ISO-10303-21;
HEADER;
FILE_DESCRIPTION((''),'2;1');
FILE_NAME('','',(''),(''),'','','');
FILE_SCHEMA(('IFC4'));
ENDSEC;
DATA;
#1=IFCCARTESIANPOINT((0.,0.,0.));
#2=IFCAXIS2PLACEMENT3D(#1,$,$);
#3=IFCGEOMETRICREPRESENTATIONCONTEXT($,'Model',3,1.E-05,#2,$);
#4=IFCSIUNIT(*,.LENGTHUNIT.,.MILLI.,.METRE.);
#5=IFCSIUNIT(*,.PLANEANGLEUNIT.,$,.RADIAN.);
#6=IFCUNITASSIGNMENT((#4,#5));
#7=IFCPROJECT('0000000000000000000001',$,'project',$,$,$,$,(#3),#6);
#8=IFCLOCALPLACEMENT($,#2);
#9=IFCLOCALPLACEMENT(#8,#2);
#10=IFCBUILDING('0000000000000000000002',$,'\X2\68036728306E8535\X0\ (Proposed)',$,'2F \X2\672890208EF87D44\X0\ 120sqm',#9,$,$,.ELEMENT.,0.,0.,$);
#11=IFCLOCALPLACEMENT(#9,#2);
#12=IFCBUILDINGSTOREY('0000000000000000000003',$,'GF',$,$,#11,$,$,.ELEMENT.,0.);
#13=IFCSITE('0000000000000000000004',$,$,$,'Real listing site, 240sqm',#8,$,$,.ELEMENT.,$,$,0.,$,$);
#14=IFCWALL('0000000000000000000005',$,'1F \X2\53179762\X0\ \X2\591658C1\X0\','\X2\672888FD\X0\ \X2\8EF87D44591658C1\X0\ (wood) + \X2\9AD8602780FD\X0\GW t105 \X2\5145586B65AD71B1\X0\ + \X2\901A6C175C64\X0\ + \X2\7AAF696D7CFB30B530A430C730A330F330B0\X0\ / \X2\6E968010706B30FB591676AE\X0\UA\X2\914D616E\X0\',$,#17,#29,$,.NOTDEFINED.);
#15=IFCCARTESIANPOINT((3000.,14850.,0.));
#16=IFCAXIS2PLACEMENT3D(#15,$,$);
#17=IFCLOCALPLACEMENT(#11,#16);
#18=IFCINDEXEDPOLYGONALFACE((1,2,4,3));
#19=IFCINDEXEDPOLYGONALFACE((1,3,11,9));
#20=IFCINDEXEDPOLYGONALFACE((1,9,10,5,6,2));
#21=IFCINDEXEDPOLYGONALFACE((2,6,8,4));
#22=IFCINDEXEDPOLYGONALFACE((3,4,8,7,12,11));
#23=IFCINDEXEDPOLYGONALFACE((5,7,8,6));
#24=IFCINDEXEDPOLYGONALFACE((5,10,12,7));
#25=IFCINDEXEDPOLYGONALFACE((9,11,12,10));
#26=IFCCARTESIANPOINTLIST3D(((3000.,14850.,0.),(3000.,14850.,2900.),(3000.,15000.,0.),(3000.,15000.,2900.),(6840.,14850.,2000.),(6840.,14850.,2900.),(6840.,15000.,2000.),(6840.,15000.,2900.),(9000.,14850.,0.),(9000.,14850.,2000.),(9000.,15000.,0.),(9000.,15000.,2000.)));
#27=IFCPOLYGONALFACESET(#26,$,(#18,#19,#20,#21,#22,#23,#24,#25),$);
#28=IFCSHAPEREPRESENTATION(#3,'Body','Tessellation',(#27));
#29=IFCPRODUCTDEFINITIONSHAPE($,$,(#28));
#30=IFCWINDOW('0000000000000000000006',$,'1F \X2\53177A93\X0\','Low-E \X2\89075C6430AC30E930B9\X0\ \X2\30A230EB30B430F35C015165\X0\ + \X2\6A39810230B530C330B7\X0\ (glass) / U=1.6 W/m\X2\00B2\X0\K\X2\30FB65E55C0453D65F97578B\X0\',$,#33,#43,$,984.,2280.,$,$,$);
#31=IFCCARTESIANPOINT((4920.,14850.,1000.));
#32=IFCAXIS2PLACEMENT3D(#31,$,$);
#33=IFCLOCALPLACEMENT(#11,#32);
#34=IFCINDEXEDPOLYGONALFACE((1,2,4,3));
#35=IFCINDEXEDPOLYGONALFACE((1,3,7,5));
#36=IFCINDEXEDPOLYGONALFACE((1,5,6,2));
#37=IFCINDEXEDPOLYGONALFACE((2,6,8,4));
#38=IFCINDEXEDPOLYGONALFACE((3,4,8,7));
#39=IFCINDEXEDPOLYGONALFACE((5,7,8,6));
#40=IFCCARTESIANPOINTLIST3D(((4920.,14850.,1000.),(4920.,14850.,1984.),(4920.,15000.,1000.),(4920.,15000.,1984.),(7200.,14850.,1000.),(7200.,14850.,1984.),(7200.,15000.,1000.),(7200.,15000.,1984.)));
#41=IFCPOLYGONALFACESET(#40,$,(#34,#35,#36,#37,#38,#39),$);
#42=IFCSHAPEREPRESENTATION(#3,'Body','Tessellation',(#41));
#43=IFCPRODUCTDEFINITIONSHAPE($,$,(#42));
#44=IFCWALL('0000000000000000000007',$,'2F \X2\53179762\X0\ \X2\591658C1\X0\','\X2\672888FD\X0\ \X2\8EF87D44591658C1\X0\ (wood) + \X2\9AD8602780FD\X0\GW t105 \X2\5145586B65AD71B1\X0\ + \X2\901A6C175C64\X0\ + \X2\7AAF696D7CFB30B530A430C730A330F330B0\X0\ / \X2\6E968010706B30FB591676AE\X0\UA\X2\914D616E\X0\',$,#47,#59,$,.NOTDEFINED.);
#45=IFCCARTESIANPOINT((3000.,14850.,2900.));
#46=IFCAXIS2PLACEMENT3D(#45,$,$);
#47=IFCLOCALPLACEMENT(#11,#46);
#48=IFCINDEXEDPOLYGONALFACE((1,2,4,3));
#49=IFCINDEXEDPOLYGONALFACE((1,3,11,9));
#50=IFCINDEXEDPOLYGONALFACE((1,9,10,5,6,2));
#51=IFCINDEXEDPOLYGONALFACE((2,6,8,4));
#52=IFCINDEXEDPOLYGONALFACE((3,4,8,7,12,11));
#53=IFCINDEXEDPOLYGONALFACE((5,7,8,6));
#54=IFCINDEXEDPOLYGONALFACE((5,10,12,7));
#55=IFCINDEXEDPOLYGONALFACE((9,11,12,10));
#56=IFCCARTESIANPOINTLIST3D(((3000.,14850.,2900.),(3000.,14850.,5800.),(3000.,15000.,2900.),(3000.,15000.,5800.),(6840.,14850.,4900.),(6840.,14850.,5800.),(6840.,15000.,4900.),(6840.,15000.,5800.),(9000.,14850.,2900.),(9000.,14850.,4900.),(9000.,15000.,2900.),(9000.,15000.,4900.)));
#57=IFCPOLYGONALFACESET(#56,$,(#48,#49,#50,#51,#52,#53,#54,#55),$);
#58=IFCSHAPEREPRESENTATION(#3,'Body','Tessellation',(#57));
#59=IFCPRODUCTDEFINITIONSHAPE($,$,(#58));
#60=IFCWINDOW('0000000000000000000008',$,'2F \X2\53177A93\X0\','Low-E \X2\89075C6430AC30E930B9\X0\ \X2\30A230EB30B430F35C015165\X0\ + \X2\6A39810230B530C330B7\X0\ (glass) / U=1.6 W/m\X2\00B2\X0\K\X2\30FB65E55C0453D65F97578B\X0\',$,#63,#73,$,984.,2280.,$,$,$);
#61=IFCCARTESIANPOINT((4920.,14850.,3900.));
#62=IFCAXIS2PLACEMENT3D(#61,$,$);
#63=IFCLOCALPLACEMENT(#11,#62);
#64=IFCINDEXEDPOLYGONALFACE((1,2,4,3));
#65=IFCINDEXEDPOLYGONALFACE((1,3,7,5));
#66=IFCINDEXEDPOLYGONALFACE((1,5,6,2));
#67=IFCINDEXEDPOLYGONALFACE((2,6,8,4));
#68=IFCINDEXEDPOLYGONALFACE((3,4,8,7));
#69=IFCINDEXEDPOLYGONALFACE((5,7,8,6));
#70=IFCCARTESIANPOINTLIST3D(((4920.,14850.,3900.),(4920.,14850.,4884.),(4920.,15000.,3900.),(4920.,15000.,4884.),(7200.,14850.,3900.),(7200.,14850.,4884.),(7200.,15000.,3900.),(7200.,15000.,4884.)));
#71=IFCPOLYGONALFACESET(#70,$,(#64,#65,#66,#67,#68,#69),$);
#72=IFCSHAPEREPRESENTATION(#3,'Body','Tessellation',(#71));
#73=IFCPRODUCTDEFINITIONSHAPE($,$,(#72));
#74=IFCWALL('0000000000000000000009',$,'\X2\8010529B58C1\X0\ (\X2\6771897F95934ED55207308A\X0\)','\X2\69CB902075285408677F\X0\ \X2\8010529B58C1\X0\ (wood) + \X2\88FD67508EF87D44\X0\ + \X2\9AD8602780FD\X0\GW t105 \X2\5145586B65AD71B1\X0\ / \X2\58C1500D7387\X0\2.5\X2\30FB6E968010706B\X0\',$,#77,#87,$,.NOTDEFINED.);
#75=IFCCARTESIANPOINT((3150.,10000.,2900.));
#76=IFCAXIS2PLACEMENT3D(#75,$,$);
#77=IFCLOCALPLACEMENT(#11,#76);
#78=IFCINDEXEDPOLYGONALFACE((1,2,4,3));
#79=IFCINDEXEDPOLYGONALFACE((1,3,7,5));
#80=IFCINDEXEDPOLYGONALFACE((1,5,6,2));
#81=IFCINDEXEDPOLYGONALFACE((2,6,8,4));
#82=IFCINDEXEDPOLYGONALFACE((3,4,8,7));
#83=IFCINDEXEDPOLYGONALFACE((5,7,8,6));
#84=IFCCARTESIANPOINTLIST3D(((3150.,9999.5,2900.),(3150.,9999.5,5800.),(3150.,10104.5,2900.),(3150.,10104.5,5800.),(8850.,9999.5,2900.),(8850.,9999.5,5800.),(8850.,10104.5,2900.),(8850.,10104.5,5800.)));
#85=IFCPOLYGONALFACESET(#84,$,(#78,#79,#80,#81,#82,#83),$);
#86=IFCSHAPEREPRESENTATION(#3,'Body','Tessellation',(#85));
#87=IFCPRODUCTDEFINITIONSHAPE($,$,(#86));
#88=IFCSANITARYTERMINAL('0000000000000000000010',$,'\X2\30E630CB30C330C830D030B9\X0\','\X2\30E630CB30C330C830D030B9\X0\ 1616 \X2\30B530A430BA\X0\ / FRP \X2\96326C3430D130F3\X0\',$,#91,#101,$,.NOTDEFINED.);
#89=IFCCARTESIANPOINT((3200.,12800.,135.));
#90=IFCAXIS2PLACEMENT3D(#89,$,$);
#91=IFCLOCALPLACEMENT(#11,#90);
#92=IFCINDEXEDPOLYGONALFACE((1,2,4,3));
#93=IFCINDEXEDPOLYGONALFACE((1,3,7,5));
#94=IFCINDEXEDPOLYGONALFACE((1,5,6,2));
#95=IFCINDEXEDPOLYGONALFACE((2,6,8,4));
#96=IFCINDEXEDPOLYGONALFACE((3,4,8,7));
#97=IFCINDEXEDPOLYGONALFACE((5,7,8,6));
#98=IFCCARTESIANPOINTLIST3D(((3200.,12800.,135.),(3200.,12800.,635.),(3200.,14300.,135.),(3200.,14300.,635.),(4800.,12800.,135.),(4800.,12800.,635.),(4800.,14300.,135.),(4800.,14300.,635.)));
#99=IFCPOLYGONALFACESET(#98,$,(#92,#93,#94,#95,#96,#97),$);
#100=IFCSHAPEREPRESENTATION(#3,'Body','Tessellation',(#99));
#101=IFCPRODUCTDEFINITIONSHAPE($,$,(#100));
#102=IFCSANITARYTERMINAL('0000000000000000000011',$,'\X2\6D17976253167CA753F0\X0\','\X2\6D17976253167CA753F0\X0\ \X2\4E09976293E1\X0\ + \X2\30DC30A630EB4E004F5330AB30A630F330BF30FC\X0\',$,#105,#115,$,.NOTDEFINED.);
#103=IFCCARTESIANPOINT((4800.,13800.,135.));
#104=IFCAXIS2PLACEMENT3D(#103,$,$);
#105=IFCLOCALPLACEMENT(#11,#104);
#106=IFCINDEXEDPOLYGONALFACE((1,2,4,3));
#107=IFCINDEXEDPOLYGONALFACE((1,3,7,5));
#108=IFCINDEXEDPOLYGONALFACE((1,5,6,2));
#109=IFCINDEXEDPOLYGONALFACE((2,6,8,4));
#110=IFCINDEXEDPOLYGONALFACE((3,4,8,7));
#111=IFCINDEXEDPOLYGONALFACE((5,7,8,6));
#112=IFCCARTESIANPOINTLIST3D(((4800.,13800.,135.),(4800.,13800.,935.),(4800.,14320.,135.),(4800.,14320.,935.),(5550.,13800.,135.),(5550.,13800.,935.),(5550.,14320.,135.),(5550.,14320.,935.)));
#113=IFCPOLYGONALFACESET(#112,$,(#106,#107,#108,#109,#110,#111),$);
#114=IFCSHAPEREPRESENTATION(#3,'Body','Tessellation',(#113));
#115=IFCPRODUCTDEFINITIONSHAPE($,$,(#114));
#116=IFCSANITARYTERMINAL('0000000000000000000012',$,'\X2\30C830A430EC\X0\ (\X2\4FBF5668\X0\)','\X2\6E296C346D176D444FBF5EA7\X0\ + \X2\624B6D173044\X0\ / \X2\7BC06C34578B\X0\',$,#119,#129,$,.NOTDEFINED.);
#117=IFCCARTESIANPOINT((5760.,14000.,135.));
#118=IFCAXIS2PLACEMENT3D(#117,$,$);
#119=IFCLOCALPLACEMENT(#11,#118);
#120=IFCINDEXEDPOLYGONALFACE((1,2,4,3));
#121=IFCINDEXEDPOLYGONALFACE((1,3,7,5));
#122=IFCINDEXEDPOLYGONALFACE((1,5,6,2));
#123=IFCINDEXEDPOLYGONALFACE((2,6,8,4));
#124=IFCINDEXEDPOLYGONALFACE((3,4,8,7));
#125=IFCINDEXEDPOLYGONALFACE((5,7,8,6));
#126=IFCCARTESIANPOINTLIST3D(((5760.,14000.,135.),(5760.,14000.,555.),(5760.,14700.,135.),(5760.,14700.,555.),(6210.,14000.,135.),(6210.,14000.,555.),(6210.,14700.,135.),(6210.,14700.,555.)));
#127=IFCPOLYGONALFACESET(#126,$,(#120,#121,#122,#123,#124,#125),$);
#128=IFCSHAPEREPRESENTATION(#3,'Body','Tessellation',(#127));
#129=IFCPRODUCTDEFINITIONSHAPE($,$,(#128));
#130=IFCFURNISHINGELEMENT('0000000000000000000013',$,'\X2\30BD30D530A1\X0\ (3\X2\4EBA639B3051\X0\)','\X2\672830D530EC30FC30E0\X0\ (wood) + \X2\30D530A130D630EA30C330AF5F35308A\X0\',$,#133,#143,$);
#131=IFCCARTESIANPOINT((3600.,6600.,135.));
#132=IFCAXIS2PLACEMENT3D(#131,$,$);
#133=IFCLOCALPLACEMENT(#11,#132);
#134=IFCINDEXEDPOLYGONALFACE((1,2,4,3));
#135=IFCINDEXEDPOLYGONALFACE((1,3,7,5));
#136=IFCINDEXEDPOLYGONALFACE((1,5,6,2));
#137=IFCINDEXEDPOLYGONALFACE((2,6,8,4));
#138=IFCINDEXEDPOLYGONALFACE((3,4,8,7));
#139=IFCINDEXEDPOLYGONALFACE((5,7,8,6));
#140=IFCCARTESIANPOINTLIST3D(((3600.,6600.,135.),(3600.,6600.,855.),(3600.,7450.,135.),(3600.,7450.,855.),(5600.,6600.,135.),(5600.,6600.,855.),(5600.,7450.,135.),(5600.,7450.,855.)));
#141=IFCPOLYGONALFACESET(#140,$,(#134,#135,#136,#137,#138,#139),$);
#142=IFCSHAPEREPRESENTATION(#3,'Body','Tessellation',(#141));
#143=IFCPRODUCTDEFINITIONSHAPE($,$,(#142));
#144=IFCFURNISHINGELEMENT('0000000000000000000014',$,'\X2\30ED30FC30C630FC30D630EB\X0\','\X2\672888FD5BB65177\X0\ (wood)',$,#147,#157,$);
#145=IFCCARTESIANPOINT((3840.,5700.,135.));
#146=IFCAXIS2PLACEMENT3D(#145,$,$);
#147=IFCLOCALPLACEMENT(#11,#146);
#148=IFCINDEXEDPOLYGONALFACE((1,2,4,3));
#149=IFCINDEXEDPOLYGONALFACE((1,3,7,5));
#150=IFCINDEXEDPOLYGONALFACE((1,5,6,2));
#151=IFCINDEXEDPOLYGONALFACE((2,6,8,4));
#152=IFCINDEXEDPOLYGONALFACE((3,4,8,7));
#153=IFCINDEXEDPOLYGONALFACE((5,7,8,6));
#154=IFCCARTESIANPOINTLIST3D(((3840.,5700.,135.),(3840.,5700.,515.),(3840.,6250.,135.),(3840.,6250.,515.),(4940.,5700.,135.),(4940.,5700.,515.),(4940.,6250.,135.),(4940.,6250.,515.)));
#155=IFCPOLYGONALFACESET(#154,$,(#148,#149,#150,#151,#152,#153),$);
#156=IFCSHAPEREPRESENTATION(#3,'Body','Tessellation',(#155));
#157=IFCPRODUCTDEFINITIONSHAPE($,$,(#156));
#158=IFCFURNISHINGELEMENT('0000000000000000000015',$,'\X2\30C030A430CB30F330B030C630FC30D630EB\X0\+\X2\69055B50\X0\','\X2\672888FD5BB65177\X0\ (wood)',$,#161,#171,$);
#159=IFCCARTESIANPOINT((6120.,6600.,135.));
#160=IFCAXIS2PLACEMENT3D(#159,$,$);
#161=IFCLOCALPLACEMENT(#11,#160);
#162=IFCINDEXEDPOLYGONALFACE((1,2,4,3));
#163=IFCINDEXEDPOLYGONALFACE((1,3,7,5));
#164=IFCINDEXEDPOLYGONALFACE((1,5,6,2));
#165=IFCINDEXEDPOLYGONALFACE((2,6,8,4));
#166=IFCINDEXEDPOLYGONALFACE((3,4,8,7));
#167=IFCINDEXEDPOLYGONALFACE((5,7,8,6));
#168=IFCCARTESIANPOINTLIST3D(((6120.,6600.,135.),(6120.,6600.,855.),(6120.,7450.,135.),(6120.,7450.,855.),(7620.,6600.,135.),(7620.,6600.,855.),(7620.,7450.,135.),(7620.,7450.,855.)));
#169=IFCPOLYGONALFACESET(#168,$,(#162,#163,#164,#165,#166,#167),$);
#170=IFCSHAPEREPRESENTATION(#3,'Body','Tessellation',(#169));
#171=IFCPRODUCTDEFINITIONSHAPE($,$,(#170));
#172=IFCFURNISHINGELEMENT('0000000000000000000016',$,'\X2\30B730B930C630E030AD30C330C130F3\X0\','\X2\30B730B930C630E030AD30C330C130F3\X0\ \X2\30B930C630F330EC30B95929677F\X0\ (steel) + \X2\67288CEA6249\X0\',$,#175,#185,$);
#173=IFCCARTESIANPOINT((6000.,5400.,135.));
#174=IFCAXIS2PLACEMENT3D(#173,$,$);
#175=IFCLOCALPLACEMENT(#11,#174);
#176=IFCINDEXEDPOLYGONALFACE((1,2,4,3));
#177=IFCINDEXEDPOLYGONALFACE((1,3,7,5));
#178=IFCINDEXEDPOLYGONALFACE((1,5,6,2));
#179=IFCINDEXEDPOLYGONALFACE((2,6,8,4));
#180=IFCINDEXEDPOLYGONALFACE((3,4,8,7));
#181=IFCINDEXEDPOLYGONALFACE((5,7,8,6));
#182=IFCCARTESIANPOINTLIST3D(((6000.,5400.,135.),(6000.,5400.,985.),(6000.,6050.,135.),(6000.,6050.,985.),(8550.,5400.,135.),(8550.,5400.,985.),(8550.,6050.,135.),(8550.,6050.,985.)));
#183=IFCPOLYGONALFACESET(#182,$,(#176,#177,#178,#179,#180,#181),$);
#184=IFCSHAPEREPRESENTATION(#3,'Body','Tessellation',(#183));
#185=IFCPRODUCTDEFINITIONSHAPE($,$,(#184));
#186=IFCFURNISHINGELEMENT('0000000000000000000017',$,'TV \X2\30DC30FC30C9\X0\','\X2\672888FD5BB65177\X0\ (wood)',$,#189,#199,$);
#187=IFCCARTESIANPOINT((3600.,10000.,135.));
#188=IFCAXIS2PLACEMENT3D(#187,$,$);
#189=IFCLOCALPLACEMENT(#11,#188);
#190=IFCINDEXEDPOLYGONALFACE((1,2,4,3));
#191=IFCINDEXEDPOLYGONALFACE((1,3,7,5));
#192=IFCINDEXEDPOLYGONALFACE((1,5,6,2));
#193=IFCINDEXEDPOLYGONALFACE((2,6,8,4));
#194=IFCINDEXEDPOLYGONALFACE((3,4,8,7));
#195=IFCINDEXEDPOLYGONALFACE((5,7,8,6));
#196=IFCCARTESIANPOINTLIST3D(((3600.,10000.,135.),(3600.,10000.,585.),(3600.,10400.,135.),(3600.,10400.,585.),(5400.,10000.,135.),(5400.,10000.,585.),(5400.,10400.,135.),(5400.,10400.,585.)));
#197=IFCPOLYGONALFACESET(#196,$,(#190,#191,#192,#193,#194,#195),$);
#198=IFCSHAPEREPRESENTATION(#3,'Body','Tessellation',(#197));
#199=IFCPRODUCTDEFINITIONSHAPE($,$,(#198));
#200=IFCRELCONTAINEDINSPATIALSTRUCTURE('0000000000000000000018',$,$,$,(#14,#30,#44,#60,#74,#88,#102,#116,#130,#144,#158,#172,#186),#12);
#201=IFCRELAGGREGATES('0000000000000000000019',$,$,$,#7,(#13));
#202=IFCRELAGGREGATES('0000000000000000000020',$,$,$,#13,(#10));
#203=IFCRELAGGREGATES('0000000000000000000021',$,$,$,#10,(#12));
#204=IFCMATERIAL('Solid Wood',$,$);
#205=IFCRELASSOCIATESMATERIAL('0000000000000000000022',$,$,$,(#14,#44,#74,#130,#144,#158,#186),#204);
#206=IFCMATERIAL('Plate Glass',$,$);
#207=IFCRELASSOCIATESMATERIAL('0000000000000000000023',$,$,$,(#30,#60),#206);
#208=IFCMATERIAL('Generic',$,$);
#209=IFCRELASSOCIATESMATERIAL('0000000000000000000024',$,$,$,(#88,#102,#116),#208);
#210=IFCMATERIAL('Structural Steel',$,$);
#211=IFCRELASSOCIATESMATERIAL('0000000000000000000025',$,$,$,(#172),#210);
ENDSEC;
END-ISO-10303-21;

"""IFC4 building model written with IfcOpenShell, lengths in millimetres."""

from ifc_helpers import new_model, si_unit, frame, frame_2d, origin, place, context, project, spatial, rectangle, extrude, material, element, fill, save


model = new_model("IFC4")

# Units and contexts
model_context = context("Model", 3, precision=1e-05, world=origin())
ifc_project = project(units=[si_unit("LENGTHUNIT", "METRE", prefix="MILLI"), si_unit("PLANEANGLEUNIT", "RADIAN")], contexts=[model_context])

# Site, building, storey
site_placement = place(None, origin())
site = spatial("IfcSite", under=ifc_project, at=site_placement, ObjectType="Real listing site, 240sqm", CompositionType="ELEMENT", RefElevation=0.0)
building_placement = place(site_placement, origin())
building = spatial("IfcBuilding", under=site, at=building_placement, Name="栃木の蔵 (Proposed)", ObjectType="2F 木造軸組 120sqm", CompositionType="ELEMENT", ElevationOfRefHeight=0.0, ElevationOfTerrain=0.0)
storey_placement = place(building_placement, origin())
storey = spatial("IfcBuildingStorey", under=building, at=storey_placement, Name="GF", CompositionType="ELEMENT", Elevation=0.0)

# Wall, opening, window
ifc_material_1 = material(Name="Solid Wood")
wall_1_placement = place(storey_placement, frame((3000.0, 14850.0, 0.0)))
wall_1 = element("IfcWall", 1, at=wall_1_placement, inside=storey, material=ifc_material_1, Name="1F 北面 外壁", Description="木製 軸組外壁 (wood) + 高性能GW t105 充填断熱 + 通気層 + 窯業系サイディング / 準耐火・外皮UA配慮", PredefinedType="NOTDEFINED", context=model_context, shape_type="SweptSolid", body=[
    extrude(rectangle(XDim=6000.0, YDim=150.0, at=frame_2d((3000.0, 75.0))), frame((3000.0, 14850.0, 0.0)), (0.0, 0.0, 1.0), 2900.0),
])
opening_1_placement = place(storey_placement, frame((4920.0, 14850.0, 1000.0)))
opening_1 = element("IfcOpeningElement", 2, at=opening_1_placement, cuts=wall_1, PredefinedType="NOTDEFINED", context=model_context, shape_type="SweptSolid", body=[
    extrude(rectangle(XDim=2280.0, YDim=150.0, at=frame_2d((1140.0, 75.0))), frame((4920.0, 14850.0, 1000.0)), (0.0, 0.0, 1.0), 984.0),
])
ifc_material_2 = material(Name="Plate Glass")
window_1_placement = place(storey_placement, frame((4920.0, 14850.0, 1000.0)))
window_1 = element("IfcWindow", 3, at=window_1_placement, inside=storey, material=ifc_material_2, Name="1F 北窓", Description="Low-E 複層ガラス アルゴン封入 + 樹脂サッシ (glass) / U=1.6 W/m²K・日射取得型", OverallHeight=984.0, OverallWidth=2280.0, context=model_context, shape_type="SweptSolid", body=[
    extrude(rectangle(XDim=2280.0, YDim=150.0, at=frame_2d((1140.0, 75.0))), frame((4920.0, 14850.0, 1000.0)), (0.0, 0.0, 1.0), 984.0),
])
fill(opening_1, window_1)

# Wall, opening, window
wall_2_placement = place(storey_placement, frame((3000.0, 14850.0, 2900.0)))
wall_2 = element("IfcWall", 4, at=wall_2_placement, inside=storey, material=ifc_material_1, Name="2F 北面 外壁", Description="木製 軸組外壁 (wood) + 高性能GW t105 充填断熱 + 通気層 + 窯業系サイディング / 準耐火・外皮UA配慮", PredefinedType="NOTDEFINED", context=model_context, shape_type="SweptSolid", body=[
    extrude(rectangle(XDim=6000.0, YDim=150.0, at=frame_2d((3000.0, 75.0))), frame((3000.0, 14850.0, 2900.0)), (0.0, 0.0, 1.0), 2900.0),
])
opening_2_placement = place(storey_placement, frame((4920.0, 14850.0, 3900.0)))
opening_2 = element("IfcOpeningElement", 5, at=opening_2_placement, cuts=wall_2, PredefinedType="NOTDEFINED", context=model_context, shape_type="SweptSolid", body=[
    extrude(rectangle(XDim=2280.0, YDim=150.0, at=frame_2d((1140.0, 75.0))), frame((4920.0, 14850.0, 3900.0)), (0.0, 0.0, 1.0), 984.0),
])
window_2_placement = place(storey_placement, frame((4920.0, 14850.0, 3900.0)))
window_2 = element("IfcWindow", 6, at=window_2_placement, inside=storey, material=ifc_material_2, Name="2F 北窓", Description="Low-E 複層ガラス アルゴン封入 + 樹脂サッシ (glass) / U=1.6 W/m²K・日射取得型", OverallHeight=984.0, OverallWidth=2280.0, context=model_context, shape_type="SweptSolid", body=[
    extrude(rectangle(XDim=2280.0, YDim=150.0, at=frame_2d((1140.0, 75.0))), frame((4920.0, 14850.0, 3900.0)), (0.0, 0.0, 1.0), 984.0),
])
fill(opening_2, window_2)

# Wall
wall_3_placement = place(storey_placement, frame((3150.0, 10000.0, 2900.0)))
element("IfcWall", 7, at=wall_3_placement, inside=storey, material=ifc_material_1, Name="耐力壁 (東西間仕切り)", Description="構造用合板 耐力壁 (wood) + 製材軸組 + 高性能GW t105 充填断熱 / 壁倍率2.5・準耐火", PredefinedType="NOTDEFINED", context=model_context, shape_type="SweptSolid", body=[
    extrude(rectangle(XDim=5700.0, YDim=105.0, at=frame_2d((2850.0, 52.0))), frame((3150.0, 10000.0, 2900.0)), (0.0, 0.0, 1.0), 2900.0),
])

# Sanitary terminals
ifc_material_3 = material(Name="Generic")
sanitary_terminal_1_placement = place(storey_placement, frame((3200.0, 12800.0, 135.0)))
element("IfcSanitaryTerminal", 8, at=sanitary_terminal_1_placement, inside=storey, material=ifc_material_3, Name="ユニットバス", Description="ユニットバス 1616 サイズ / FRP 防水パン", PredefinedType="NOTDEFINED", context=model_context, shape_type="SweptSolid", body=[
    extrude(rectangle(XDim=1600.0, YDim=1500.0, at=frame_2d((800.0, 750.0))), frame((3200.0, 12800.0, 135.0)), (0.0, 0.0, 1.0), 500.0),
])
sanitary_terminal_2_placement = place(storey_placement, frame((4800.0, 13800.0, 135.0)))
element("IfcSanitaryTerminal", 9, at=sanitary_terminal_2_placement, inside=storey, material=ifc_material_3, Name="洗面化粧台", Description="洗面化粧台 三面鏡 + ボウル一体カウンター", PredefinedType="NOTDEFINED", context=model_context, shape_type="SweptSolid", body=[
    extrude(rectangle(XDim=750.0, YDim=520.0, at=frame_2d((375.0, 260.0))), frame((4800.0, 13800.0, 135.0)), (0.0, 0.0, 1.0), 800.0),
])
sanitary_terminal_3_placement = place(storey_placement, frame((5760.0, 14000.0, 135.0)))
element("IfcSanitaryTerminal", 10, at=sanitary_terminal_3_placement, inside=storey, material=ifc_material_3, Name="トイレ (便器)", Description="温水洗浄便座 + 手洗い / 節水型", PredefinedType="NOTDEFINED", context=model_context, shape_type="SweptSolid", body=[
    extrude(rectangle(XDim=450.0, YDim=700.0, at=frame_2d((225.0, 350.0))), frame((5760.0, 14000.0, 135.0)), (0.0, 0.0, 1.0), 420.0),
])

# Furnishing elements
furnishing_1_placement = place(storey_placement, frame((3600.0, 6600.0, 135.0)))
element("IfcFurnishingElement", 11, at=furnishing_1_placement, inside=storey, material=ifc_material_1, Name="ソファ (3人掛け)", Description="木フレーム (wood) + ファブリック張り", context=model_context, shape_type="SweptSolid", body=[
    extrude(rectangle(XDim=2000.0, YDim=850.0, at=frame_2d((1000.0, 425.0))), frame((3600.0, 6600.0, 135.0)), (0.0, 0.0, 1.0), 720.0),
])
furnishing_2_placement = place(storey_placement, frame((3840.0, 5700.0, 135.0)))
element("IfcFurnishingElement", 12, at=furnishing_2_placement, inside=storey, material=ifc_material_1, Name="ローテーブル", Description="木製家具 (wood)", context=model_context, shape_type="SweptSolid", body=[
    extrude(rectangle(XDim=1100.0, YDim=550.0, at=frame_2d((550.0, 275.0))), frame((3840.0, 5700.0, 135.0)), (0.0, 0.0, 1.0), 380.0),
])
furnishing_3_placement = place(storey_placement, frame((6120.0, 6600.0, 135.0)))
element("IfcFurnishingElement", 13, at=furnishing_3_placement, inside=storey, material=ifc_material_1, Name="ダイニングテーブル+椅子", Description="木製家具 (wood)", context=model_context, shape_type="SweptSolid", body=[
    extrude(rectangle(XDim=1500.0, YDim=850.0, at=frame_2d((750.0, 425.0))), frame((6120.0, 6600.0, 135.0)), (0.0, 0.0, 1.0), 720.0),
])
ifc_material_4 = material(Name="Structural Steel")
furnishing_4_placement = place(storey_placement, frame((6000.0, 5400.0, 135.0)))
element("IfcFurnishingElement", 14, at=furnishing_4_placement, inside=storey, material=ifc_material_4, Name="システムキッチン", Description="システムキッチン ステンレス天板 (steel) + 木質扉", context=model_context, shape_type="SweptSolid", body=[
    extrude(rectangle(XDim=2550.0, YDim=650.0, at=frame_2d((1275.0, 325.0))), frame((6000.0, 5400.0, 135.0)), (0.0, 0.0, 1.0), 850.0),
])
furnishing_5_placement = place(storey_placement, frame((3600.0, 10000.0, 135.0)))
element("IfcFurnishingElement", 15, at=furnishing_5_placement, inside=storey, material=ifc_material_1, Name="TV ボード", Description="木製家具 (wood)", context=model_context, shape_type="SweptSolid", body=[
    extrude(rectangle(XDim=1800.0, YDim=400.0, at=frame_2d((900.0, 200.0))), frame((3600.0, 10000.0, 135.0)), (0.0, 0.0, 1.0), 450.0),
])

save(model, "model.ifc")
